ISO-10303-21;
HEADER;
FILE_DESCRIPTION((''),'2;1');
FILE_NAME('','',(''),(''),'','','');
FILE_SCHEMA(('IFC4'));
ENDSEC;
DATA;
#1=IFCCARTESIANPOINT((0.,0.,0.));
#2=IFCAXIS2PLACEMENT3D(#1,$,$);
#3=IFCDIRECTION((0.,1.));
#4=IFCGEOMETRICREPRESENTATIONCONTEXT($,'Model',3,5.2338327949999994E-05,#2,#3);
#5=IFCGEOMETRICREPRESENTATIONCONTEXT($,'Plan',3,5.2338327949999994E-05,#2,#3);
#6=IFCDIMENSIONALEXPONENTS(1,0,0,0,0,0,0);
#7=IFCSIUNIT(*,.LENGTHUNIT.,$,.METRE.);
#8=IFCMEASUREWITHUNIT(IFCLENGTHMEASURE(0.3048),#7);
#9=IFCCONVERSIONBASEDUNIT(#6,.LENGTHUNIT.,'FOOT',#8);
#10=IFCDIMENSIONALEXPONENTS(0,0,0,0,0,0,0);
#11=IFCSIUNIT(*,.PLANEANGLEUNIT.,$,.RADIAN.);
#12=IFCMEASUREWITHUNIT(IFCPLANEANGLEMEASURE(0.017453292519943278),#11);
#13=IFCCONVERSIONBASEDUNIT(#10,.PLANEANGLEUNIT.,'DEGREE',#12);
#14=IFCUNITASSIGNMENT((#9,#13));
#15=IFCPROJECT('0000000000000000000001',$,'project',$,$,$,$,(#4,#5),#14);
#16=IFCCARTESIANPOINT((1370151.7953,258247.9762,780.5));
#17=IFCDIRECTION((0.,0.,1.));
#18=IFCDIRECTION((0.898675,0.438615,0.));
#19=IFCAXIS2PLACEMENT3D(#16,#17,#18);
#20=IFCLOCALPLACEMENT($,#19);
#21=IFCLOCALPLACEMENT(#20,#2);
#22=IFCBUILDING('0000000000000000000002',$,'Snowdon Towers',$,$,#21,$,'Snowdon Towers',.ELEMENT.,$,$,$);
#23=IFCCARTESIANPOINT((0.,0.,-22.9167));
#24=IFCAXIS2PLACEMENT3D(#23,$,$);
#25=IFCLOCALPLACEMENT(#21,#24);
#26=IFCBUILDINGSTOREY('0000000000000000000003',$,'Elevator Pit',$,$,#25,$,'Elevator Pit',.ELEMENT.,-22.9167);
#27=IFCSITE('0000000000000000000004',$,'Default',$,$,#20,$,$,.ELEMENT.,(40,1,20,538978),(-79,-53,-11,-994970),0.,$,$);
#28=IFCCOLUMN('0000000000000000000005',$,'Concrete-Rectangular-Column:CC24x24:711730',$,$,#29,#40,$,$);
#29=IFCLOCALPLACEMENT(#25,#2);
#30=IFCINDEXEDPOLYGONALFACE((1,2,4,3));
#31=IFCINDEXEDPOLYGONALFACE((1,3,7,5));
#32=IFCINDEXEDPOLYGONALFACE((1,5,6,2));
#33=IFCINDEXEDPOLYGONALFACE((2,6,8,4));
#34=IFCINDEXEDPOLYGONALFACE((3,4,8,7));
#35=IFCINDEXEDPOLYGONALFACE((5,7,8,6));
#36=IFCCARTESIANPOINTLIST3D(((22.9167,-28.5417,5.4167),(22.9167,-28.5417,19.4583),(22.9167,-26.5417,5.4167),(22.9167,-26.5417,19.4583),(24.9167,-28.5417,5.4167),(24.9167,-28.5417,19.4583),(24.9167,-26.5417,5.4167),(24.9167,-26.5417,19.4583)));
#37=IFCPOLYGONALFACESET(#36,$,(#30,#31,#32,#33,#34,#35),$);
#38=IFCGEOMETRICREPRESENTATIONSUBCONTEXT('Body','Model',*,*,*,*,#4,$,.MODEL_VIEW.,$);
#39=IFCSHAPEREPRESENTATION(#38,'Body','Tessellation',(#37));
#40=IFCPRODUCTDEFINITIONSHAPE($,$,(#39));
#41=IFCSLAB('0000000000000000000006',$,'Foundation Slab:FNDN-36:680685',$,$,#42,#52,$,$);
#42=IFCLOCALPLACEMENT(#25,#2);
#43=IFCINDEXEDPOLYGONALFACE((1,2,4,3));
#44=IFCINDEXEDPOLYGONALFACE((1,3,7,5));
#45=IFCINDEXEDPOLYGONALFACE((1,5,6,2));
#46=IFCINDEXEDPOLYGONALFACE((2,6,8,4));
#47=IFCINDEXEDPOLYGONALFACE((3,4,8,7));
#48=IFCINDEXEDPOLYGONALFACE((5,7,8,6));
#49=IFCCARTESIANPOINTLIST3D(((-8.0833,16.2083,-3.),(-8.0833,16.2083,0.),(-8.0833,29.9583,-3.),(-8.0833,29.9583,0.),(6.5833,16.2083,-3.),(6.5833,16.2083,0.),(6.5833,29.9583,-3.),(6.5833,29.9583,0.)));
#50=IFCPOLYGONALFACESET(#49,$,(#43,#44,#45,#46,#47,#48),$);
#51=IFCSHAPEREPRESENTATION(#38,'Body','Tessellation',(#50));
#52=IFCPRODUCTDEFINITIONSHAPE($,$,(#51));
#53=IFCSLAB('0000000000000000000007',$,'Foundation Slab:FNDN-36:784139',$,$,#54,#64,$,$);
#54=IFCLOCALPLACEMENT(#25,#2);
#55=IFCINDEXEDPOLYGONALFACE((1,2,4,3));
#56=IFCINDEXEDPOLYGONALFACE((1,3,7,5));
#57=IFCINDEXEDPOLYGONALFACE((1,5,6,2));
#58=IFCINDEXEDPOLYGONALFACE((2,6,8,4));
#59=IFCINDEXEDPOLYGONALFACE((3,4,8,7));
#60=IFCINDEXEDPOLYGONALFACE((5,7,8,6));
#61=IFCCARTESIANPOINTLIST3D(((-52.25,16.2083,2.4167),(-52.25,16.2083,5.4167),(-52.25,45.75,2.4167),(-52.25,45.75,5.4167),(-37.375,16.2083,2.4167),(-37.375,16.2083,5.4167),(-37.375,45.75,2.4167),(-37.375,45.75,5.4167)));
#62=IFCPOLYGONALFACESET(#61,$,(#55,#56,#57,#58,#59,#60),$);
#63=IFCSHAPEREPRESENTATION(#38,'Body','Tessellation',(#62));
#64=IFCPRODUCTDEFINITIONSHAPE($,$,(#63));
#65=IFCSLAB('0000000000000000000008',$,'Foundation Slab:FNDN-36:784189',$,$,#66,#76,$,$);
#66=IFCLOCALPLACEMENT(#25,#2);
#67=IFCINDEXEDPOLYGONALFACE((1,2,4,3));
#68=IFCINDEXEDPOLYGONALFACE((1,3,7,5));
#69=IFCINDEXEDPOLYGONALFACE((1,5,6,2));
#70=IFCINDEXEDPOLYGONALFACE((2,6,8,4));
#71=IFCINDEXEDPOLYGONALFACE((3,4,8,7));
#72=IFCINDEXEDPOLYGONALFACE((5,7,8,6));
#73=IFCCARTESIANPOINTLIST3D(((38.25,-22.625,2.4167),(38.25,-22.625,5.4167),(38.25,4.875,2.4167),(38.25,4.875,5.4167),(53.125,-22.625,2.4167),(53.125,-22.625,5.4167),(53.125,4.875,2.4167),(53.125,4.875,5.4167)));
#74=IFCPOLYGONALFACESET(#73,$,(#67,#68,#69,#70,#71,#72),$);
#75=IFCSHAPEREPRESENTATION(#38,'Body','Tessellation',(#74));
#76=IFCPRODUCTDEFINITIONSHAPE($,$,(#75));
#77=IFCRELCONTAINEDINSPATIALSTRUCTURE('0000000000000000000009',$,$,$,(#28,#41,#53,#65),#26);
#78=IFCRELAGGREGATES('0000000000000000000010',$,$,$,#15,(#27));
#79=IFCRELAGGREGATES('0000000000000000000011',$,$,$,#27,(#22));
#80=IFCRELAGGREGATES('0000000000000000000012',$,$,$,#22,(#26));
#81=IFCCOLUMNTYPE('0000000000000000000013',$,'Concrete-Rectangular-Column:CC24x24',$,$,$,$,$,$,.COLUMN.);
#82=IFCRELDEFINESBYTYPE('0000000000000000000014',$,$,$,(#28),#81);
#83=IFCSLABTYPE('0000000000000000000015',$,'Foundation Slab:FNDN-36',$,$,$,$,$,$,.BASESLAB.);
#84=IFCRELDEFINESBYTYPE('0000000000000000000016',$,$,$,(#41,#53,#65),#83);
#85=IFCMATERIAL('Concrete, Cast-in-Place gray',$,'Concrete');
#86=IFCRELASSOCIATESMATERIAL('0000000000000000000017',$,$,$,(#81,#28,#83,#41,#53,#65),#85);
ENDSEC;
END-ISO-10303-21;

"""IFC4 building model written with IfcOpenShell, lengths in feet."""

from ifc_helpers import new_model, entity, si_unit, converted_unit, direction, frame, origin, place, context, subcontext, project, spatial, indexed_curve, outline, extrude, source, transform, mapped, material, type_object, type_shapes, element, save


model = new_model("IFC4")

# Units and contexts
model_context = context("Model", 3, precision=5.2338327949999994e-05, world=origin(), true_north=direction((0.0, 1.0)))
plan_context = context("Plan", 3, precision=5.2338327949999994e-05, world=origin(), true_north=direction((0.0, 1.0)))
body_context = subcontext(model_context, "Body", "Model", "MODEL_VIEW")
ifc_project = project(units=[converted_unit("LENGTHUNIT", "FOOT", entity("IfcLengthMeasure", 0.3048), si_unit("LENGTHUNIT", "METRE"), dimensions=[1, 0, 0, 0, 0, 0, 0]), converted_unit("PLANEANGLEUNIT", "DEGREE", entity("IfcPlaneAngleMeasure", 0.017453292519943278), si_unit("PLANEANGLEUNIT", "RADIAN"), dimensions=[0, 0, 0, 0, 0, 0, 0])], contexts=[model_context, plan_context])

# Site, building, storey
site_placement = place(None, frame((1370151.7953, 258247.9762, 780.5), z_axis=(0.0, 0.0, 1.0), x_axis=(0.898675, 0.438615, 0.0)))
site = spatial("IfcSite", under=ifc_project, at=site_placement, Name="Default", CompositionType="ELEMENT", RefLatitude=(40, 1, 20, 538978), RefLongitude=(-79, -53, -11, -994970), RefElevation=0.0)
building_placement = place(site_placement, origin())
building = spatial("IfcBuilding", under=site, at=building_placement, Name="Snowdon Towers", LongName="Snowdon Towers", CompositionType="ELEMENT")
storey_placement = place(building_placement, frame((0.0, 0.0, -22.9167)))
storey = spatial("IfcBuildingStorey", under=building, at=storey_placement, Name="Elevator Pit", LongName="Elevator Pit", CompositionType="ELEMENT", Elevation=-22.9167)

# Column
ifc_material = material(Name="Concrete, Cast-in-Place gray", Category="Concrete")
column_type_1 = type_object("IfcColumnType", Name="Concrete-Rectangular-Column:CC24x24", PredefinedType="COLUMN", material=ifc_material)
shared_shape_1 = source(origin(), body_context, "Body", "SweptSolid", [
    extrude(outline(indexed_curve([(-1.0, -1.0), (1.0, -1.0), (1.0, 1.0), (-1.0, 1.0), (-1.0, -1.0)], self_intersect=False)), frame((23.9167, -27.5417, -17.5), z_axis=(0.0, 0.0, 1.0), x_axis=(-1.0, 0.0, 0.0)), (0.0, 0.0, 1.0), 14.0417),
])
type_shapes(column_type_1, [shared_shape_1])
column_1_placement = place(storey_placement, frame((0.0, 0.0, 22.9167)))
element("IfcColumn", 1, at=column_1_placement, inside=storey, type_object=column_type_1, material=ifc_material, Name="Concrete-Rectangular-Column:CC24x24:711730", context=body_context, shape_type="MappedRepresentation", body=[
    mapped(shared_shape_1, transform((0.0, 0.0, 0.0), scale=1.0)),
])

# Slabs
slab_type_1 = type_object("IfcSlabType", Name="Foundation Slab:FNDN-36", PredefinedType="BASESLAB", material=ifc_material)
slab_1_placement = place(storey_placement, origin())
element("IfcSlab", 2, at=slab_1_placement, inside=storey, type_object=slab_type_1, material=ifc_material, Name="Foundation Slab:FNDN-36:680685", context=body_context, shape_type="SweptSolid", body=[
    extrude(outline(indexed_curve([(-6.875, -7.3333), (6.875, -7.3333), (6.875, 7.3333), (-6.875, 7.3333), (-6.875, -7.3333)], self_intersect=False)), frame((-0.75, 23.0833, 0.0), z_axis=(0.0, 0.0, -1.0), x_axis=(0.0, 1.0, 0.0)), (0.0, 0.0, 1.0), 3.0),
])
slab_2_placement = place(storey_placement, origin())
element("IfcSlab", 3, at=slab_2_placement, inside=storey, type_object=slab_type_1, material=ifc_material, Name="Foundation Slab:FNDN-36:784139", context=body_context, shape_type="SweptSolid", body=[
    extrude(outline(indexed_curve([(-14.7708, -7.4375), (14.7708, -7.4375), (14.7708, 7.4375), (-14.7708, 7.4375), (-14.7708, -7.4375)], self_intersect=False)), frame((-44.8125, 30.9792, 5.4167), z_axis=(0.0, 0.0, -1.0), x_axis=(0.0, 1.0, 0.0)), (0.0, 0.0, 1.0), 3.0),
])
slab_3_placement = place(storey_placement, origin())
element("IfcSlab", 4, at=slab_3_placement, inside=storey, type_object=slab_type_1, material=ifc_material, Name="Foundation Slab:FNDN-36:784189", context=body_context, shape_type="SweptSolid", body=[
    extrude(outline(indexed_curve([(-13.75, -7.4375), (13.75, -7.4375), (13.75, 7.4375), (-13.75, 7.4375), (-13.75, -7.4375)], self_intersect=False)), frame((45.6875, -8.875, 5.4167), z_axis=(0.0, 0.0, -1.0), x_axis=(0.0, 1.0, 0.0)), (0.0, 0.0, 1.0), 3.0),
])

save(model, "model.ifc")
